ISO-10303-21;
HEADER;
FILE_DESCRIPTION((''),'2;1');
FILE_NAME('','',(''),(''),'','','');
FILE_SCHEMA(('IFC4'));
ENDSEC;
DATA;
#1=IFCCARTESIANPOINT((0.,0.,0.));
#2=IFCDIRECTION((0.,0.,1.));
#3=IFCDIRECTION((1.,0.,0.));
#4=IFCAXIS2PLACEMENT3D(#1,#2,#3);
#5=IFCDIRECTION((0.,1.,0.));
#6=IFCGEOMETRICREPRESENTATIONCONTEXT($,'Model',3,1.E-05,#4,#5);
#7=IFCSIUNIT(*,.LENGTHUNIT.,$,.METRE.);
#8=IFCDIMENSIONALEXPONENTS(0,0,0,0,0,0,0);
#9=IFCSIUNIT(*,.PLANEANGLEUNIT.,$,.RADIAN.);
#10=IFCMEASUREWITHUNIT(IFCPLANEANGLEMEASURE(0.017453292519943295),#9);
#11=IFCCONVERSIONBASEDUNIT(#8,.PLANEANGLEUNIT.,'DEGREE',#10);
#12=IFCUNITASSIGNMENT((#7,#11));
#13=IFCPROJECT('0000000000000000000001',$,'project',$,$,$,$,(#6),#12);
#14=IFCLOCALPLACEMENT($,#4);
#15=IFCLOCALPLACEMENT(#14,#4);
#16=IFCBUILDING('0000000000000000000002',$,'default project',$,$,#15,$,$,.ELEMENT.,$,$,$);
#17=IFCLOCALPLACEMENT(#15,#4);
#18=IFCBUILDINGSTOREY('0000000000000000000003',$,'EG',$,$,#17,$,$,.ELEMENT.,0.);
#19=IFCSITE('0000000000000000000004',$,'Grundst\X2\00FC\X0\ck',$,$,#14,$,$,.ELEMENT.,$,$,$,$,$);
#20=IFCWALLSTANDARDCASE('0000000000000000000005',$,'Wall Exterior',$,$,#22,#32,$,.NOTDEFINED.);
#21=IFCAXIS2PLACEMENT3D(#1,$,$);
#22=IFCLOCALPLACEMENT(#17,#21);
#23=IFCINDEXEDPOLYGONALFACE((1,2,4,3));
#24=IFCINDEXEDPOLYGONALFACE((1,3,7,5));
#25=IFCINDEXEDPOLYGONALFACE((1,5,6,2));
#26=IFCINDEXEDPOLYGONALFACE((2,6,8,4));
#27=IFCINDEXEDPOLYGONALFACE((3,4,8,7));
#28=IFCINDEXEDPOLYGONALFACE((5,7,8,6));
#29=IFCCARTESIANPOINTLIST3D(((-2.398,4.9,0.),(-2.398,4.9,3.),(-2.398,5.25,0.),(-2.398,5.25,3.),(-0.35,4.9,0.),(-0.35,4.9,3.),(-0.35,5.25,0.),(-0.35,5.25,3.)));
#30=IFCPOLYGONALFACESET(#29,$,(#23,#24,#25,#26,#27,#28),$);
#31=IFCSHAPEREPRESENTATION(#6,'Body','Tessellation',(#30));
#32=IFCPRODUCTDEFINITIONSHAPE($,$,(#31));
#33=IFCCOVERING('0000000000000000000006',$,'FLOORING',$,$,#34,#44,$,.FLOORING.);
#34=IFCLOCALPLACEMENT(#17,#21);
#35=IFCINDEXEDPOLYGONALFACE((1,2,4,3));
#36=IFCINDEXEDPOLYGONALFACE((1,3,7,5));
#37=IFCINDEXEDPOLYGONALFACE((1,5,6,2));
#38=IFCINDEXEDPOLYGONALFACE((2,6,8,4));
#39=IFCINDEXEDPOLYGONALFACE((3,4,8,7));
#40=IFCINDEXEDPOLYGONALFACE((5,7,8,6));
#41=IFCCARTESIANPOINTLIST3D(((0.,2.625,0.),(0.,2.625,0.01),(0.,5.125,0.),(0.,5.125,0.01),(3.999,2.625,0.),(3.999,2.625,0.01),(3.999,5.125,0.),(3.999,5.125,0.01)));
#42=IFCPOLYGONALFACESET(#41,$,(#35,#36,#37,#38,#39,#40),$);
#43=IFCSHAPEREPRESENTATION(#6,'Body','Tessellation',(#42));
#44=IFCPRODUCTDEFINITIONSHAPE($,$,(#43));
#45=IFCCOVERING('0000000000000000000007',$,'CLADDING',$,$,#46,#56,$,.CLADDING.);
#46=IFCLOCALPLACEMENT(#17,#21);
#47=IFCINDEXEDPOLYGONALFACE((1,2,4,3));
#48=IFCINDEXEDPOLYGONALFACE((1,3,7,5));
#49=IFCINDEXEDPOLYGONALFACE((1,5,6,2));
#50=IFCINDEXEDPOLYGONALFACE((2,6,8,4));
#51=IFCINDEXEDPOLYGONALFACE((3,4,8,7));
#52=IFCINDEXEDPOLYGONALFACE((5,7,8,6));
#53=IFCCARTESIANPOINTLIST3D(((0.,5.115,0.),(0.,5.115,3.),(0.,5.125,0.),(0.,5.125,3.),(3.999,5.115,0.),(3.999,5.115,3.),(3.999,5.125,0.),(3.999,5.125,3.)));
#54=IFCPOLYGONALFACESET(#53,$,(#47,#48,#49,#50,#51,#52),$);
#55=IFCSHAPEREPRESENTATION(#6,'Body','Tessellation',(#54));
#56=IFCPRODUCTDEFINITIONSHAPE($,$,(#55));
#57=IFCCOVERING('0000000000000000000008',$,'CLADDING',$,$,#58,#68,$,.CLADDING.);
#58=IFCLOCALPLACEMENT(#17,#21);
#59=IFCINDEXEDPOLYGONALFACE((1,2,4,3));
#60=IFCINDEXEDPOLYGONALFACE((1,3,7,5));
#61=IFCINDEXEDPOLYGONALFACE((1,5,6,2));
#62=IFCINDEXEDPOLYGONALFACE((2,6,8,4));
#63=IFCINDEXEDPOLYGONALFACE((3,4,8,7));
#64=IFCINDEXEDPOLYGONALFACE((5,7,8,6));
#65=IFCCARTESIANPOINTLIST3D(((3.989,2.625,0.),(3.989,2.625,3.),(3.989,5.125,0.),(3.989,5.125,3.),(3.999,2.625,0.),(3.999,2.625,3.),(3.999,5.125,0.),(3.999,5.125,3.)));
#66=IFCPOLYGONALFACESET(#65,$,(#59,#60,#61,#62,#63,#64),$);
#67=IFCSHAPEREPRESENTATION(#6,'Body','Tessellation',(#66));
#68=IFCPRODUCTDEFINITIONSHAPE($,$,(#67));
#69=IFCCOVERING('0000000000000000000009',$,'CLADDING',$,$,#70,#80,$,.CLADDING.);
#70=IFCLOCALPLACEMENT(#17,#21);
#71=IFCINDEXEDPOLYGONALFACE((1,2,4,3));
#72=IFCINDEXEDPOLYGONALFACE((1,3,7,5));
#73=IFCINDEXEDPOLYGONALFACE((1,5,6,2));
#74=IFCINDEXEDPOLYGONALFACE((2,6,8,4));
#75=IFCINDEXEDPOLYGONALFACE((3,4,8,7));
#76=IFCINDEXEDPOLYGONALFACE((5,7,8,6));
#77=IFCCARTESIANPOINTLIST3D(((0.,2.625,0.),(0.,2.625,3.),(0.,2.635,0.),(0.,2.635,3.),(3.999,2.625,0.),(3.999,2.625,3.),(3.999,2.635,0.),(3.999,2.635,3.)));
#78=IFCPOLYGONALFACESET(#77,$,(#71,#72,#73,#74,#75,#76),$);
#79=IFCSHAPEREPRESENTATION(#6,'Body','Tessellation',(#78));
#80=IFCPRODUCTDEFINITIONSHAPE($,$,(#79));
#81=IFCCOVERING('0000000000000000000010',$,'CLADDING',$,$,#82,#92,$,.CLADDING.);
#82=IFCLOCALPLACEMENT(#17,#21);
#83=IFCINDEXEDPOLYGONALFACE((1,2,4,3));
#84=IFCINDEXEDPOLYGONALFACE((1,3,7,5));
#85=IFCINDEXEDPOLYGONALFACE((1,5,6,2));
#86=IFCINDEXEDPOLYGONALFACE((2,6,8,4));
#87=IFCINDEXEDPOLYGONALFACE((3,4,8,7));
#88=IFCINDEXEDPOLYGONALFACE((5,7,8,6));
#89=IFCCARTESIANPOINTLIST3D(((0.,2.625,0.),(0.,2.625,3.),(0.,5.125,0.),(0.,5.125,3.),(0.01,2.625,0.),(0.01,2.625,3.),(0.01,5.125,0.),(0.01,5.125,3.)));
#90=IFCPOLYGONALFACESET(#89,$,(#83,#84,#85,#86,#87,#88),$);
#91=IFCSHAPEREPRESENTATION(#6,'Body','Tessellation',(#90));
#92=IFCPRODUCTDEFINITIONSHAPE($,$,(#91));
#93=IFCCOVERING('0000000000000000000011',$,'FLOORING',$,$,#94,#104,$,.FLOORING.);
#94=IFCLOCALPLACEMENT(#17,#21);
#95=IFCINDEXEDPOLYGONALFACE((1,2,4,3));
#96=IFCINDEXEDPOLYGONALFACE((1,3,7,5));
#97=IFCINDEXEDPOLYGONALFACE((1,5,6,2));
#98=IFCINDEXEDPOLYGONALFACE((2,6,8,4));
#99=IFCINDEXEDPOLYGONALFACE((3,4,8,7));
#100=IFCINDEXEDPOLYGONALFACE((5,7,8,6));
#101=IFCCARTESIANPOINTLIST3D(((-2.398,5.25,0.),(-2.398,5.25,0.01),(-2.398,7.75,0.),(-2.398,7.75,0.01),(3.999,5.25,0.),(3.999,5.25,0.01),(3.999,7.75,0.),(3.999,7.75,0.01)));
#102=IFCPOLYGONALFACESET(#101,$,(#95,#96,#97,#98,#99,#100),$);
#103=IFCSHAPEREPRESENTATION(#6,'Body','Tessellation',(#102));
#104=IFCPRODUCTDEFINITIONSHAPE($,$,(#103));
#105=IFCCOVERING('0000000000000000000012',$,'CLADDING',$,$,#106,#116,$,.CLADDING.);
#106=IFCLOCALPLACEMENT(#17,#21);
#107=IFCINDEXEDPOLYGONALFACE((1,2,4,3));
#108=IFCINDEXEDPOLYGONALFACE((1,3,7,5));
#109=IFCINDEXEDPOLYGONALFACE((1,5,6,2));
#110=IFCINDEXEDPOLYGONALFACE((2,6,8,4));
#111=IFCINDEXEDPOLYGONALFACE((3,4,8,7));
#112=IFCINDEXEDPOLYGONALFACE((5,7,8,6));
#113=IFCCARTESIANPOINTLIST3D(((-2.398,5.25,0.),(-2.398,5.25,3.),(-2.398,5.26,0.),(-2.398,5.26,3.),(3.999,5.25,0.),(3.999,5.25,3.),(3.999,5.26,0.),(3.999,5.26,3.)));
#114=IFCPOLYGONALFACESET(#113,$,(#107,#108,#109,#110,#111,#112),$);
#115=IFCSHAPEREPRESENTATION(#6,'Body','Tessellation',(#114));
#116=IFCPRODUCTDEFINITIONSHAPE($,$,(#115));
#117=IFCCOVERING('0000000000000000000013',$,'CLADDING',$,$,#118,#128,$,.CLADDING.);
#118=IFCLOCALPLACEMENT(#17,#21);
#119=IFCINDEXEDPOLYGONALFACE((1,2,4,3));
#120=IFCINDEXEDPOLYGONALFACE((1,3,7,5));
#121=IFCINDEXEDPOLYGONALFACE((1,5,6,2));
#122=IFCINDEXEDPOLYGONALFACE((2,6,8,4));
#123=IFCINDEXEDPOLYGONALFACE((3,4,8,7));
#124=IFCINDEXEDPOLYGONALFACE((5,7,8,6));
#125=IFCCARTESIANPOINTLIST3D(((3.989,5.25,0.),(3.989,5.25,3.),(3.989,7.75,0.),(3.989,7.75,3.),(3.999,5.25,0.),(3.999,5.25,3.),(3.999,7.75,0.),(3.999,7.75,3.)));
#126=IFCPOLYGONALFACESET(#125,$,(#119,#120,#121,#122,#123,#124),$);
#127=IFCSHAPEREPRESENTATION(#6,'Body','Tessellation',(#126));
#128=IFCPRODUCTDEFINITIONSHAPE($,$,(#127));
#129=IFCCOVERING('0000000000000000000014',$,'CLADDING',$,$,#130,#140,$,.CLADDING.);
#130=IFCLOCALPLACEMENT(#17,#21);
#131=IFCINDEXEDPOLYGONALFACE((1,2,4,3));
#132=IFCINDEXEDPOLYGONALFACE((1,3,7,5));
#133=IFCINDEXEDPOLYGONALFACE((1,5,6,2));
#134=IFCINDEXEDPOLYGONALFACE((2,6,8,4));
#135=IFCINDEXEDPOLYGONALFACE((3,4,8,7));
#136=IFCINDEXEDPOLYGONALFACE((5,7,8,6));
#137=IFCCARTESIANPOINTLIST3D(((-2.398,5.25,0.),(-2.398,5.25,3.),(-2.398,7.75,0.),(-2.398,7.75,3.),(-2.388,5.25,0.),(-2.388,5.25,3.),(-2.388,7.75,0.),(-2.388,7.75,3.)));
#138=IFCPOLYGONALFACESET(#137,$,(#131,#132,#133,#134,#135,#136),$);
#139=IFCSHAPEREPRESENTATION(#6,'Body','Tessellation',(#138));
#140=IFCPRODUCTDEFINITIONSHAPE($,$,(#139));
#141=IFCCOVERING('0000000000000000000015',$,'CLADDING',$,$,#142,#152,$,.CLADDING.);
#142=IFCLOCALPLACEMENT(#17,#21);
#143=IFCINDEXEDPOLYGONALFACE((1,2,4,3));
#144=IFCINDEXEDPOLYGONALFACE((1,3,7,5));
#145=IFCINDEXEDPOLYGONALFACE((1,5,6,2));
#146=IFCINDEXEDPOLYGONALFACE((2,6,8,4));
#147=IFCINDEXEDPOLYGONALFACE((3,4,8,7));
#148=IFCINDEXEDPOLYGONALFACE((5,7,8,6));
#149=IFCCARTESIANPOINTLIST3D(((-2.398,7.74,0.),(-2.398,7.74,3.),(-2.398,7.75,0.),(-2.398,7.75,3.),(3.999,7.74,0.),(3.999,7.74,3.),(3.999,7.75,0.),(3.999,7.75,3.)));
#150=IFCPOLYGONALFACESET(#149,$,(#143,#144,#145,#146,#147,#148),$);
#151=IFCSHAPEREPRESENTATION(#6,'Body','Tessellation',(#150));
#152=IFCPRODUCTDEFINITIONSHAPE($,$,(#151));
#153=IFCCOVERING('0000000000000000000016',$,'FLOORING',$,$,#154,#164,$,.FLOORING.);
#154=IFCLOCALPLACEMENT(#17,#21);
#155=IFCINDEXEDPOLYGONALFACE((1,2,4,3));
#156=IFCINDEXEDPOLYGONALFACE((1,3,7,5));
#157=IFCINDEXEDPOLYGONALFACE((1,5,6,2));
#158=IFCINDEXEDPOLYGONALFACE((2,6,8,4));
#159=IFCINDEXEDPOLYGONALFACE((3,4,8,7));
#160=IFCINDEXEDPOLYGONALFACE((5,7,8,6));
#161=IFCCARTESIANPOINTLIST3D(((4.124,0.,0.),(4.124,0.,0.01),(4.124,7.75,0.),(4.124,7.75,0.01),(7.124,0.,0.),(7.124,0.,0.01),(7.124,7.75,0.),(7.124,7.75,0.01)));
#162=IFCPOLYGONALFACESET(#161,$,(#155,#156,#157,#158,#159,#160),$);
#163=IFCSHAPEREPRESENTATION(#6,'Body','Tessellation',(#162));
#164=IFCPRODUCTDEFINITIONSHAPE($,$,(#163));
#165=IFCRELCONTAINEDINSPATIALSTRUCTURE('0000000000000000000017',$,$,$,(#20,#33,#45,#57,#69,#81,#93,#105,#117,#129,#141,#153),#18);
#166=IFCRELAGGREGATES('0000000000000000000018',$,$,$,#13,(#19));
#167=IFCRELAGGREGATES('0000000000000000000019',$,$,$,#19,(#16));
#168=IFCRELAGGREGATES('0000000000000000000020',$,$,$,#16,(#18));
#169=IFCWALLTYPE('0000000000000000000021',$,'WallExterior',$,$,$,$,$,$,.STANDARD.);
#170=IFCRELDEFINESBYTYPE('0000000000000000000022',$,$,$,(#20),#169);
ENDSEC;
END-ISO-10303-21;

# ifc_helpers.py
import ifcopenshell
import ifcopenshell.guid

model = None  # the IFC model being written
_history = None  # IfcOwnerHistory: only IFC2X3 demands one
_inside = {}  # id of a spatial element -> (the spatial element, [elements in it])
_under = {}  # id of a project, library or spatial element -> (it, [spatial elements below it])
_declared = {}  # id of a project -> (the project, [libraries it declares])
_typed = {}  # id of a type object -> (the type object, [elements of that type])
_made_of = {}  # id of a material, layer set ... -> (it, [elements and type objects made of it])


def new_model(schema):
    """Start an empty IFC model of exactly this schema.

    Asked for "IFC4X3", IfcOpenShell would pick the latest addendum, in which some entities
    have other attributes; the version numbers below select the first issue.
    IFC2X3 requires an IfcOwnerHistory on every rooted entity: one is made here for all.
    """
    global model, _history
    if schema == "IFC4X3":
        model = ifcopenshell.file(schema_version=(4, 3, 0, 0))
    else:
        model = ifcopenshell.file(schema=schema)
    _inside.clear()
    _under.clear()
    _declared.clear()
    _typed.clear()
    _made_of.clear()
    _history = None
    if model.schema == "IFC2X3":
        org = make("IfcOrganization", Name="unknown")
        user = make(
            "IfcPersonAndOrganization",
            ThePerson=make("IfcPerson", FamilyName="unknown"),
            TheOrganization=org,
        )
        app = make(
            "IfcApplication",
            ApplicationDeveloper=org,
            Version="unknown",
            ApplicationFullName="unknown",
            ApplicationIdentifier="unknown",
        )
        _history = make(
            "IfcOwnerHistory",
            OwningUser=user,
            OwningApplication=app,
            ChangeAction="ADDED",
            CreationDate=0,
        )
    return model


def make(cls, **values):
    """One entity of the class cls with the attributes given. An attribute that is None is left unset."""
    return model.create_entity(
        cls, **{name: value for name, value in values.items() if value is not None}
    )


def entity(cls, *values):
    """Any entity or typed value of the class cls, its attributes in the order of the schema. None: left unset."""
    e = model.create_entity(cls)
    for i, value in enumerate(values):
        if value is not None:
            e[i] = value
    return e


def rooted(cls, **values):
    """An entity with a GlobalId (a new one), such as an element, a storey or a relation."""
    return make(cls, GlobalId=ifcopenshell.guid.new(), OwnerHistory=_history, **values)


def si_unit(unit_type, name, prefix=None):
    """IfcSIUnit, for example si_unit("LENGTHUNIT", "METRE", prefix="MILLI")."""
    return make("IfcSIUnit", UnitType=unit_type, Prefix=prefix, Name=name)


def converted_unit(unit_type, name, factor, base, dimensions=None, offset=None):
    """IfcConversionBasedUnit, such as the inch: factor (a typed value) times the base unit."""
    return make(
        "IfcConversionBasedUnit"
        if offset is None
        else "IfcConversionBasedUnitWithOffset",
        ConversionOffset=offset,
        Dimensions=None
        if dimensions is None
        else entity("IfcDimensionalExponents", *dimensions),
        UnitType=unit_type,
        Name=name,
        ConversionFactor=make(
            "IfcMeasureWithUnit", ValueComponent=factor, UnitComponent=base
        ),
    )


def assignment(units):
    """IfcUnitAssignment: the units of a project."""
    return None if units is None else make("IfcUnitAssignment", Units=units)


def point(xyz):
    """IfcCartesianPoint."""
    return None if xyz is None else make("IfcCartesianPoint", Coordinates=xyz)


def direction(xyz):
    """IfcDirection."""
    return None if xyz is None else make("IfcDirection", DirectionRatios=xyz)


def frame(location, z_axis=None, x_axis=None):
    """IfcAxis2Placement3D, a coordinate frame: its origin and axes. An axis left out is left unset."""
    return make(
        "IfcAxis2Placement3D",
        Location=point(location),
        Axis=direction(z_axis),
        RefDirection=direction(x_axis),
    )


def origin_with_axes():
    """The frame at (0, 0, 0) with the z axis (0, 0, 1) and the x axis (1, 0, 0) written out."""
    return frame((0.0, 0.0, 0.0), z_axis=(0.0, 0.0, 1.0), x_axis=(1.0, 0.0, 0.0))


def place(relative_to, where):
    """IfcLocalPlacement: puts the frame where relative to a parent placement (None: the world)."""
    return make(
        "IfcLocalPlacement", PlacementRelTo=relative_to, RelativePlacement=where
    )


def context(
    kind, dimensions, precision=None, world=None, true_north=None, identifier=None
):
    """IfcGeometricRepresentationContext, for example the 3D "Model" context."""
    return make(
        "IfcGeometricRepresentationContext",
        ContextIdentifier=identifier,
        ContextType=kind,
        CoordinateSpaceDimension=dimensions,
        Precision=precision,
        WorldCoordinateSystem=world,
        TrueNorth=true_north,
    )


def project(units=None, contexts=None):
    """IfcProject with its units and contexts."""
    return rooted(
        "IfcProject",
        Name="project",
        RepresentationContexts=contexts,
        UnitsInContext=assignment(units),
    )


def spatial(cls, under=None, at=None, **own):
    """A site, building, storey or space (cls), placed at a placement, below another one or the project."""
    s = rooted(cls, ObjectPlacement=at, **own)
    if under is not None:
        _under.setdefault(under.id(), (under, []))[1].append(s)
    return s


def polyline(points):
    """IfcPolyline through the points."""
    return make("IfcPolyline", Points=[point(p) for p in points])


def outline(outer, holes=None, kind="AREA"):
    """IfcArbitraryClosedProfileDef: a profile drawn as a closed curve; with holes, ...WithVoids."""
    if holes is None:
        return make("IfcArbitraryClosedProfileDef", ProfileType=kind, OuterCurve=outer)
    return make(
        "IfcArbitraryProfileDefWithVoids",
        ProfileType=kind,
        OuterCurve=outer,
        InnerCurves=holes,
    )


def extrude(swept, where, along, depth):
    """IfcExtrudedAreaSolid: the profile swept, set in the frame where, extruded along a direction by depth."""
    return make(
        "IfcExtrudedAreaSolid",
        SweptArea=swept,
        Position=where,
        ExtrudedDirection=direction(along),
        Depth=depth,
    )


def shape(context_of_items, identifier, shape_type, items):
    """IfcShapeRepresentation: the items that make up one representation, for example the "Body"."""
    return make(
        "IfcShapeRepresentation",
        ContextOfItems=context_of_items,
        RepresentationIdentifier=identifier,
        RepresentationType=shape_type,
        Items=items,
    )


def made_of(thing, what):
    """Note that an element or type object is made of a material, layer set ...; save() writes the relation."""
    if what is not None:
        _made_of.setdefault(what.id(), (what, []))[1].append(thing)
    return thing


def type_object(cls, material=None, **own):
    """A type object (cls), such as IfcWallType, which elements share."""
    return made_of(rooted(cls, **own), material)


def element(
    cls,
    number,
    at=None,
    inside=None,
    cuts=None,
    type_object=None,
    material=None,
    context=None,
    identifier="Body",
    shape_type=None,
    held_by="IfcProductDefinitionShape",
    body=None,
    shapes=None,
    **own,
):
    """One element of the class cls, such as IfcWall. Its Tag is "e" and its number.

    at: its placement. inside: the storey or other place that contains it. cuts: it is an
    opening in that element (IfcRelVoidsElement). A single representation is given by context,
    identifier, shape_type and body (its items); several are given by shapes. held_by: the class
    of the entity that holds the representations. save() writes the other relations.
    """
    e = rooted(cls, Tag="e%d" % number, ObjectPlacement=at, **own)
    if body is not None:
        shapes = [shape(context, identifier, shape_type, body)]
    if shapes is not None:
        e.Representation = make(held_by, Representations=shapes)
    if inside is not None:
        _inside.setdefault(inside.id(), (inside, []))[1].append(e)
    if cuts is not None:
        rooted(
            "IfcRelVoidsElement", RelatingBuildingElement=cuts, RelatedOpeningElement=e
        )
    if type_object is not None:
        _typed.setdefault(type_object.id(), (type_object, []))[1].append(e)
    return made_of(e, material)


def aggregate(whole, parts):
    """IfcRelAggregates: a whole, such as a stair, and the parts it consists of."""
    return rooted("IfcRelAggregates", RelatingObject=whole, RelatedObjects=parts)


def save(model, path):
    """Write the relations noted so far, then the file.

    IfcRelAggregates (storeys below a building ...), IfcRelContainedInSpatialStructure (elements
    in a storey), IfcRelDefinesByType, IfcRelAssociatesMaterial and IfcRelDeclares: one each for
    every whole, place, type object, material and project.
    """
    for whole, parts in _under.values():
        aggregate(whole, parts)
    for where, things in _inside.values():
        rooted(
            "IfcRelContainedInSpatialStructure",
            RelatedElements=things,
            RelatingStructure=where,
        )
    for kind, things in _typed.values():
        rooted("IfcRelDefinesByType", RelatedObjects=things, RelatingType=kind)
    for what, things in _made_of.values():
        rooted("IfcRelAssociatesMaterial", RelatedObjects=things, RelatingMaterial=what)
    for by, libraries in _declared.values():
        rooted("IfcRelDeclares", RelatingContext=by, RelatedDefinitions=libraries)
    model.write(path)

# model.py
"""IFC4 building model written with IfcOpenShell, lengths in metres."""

from ifc_helpers import new_model, entity, si_unit, converted_unit, direction, frame, origin_with_axes, place, context, project, spatial, polyline, outline, extrude, type_object, element, save


model = new_model("IFC4")

# Units and contexts
model_context = context("Model", 3, precision=1e-05, world=origin_with_axes(), true_north=direction((0.0, 1.0, 0.0)))
ifc_project = project(units=[si_unit("LENGTHUNIT", "METRE"), converted_unit("PLANEANGLEUNIT", "DEGREE", entity("IfcPlaneAngleMeasure", 0.017453292519943295), si_unit("PLANEANGLEUNIT", "RADIAN"), dimensions=[0, 0, 0, 0, 0, 0, 0])], contexts=[model_context])

# Site, building, storey
site_placement = place(None, origin_with_axes())
site = spatial("IfcSite", under=ifc_project, at=site_placement, Name="Grundstück", CompositionType="ELEMENT")
building_placement = place(site_placement, origin_with_axes())
building = spatial("IfcBuilding", under=site, at=building_placement, Name="default project", CompositionType="ELEMENT")
placement_1 = place(building_placement, origin_with_axes())
storey = spatial("IfcBuildingStorey", under=building, at=placement_1, Name="EG", CompositionType="ELEMENT", Elevation=0.0)

# Wall
wall_type_1 = type_object("IfcWallType", Name="WallExterior", PredefinedType="STANDARD")
placement_2 = place(placement_1, frame((-0.175, 5.075, 0.0), z_axis=(0.0, 0.0, 1.0), x_axis=(-1.0, 0.0, 0.0)))
element("IfcWallStandardCase", 1, at=placement_2, inside=storey, type_object=wall_type_1, Name="Wall Exterior", PredefinedType="NOTDEFINED", context=model_context, shape_type="SweptSolid", body=[
    extrude(outline(polyline([(0.175, -0.175), (2.223, -0.175), (2.223, 0.175), (0.175, 0.175), (0.175, -0.175)])), origin_with_axes(), (0.0, 0.0, 1.0), 3.0),
])

# Coverings
element("IfcCovering", 2, at=placement_1, inside=storey, Name="FLOORING", PredefinedType="FLOORING", context=model_context, shape_type="SweptSolid", body=[
    extrude(outline(polyline([(3.999, 5.125), (0.0, 5.125), (0.0, 2.625), (3.999, 2.625), (3.999, 5.125)])), origin_with_axes(), (0.0, 0.0, 1.0), 0.01),
])
element("IfcCovering", 3, at=placement_1, inside=storey, Name="CLADDING", PredefinedType="CLADDING", context=model_context, shape_type="SweptSolid", body=[
    extrude(outline(polyline([(0.0, 5.115), (3.999, 5.115), (3.999, 5.125), (0.0, 5.125), (0.0, 5.115)])), origin_with_axes(), (0.0, 0.0, 1.0), 3.0),
])
element("IfcCovering", 4, at=placement_1, inside=storey, Name="CLADDING", PredefinedType="CLADDING", context=model_context, shape_type="SweptSolid", body=[
    extrude(outline(polyline([(3.989, 5.125), (3.989, 2.625), (3.999, 2.625), (3.999, 5.125), (3.989, 5.125)])), origin_with_axes(), (0.0, 0.0, 1.0), 3.0),
])
element("IfcCovering", 5, at=placement_1, inside=storey, Name="CLADDING", PredefinedType="CLADDING", context=model_context, shape_type="SweptSolid", body=[
    extrude(outline(polyline([(3.999, 2.635), (0.0, 2.635), (0.0, 2.625), (3.999, 2.625), (3.999, 2.635)])), origin_with_axes(), (0.0, 0.0, 1.0), 3.0),
])
element("IfcCovering", 6, at=placement_1, inside=storey, Name="CLADDING", PredefinedType="CLADDING", context=model_context, shape_type="SweptSolid", body=[
    extrude(outline(polyline([(0.01, 2.625), (0.01, 5.125), (0.0, 5.125), (0.0, 2.625), (0.01, 2.625)])), origin_with_axes(), (0.0, 0.0, 1.0), 3.0),
])
element("IfcCovering", 7, at=placement_1, inside=storey, Name="FLOORING", PredefinedType="FLOORING", context=model_context, shape_type="SweptSolid", body=[
    extrude(outline(polyline([(3.999, 7.75), (-2.398, 7.75), (-2.398, 5.25), (3.999, 5.25), (3.999, 7.75)])), origin_with_axes(), (0.0, 0.0, 1.0), 0.01),
])
element("IfcCovering", 8, at=placement_1, inside=storey, Name="CLADDING", PredefinedType="CLADDING", context=model_context, shape_type="SweptSolid", body=[
    extrude(outline(polyline([(3.999, 5.26), (-2.398, 5.26), (-2.398, 5.25), (3.999, 5.25), (3.999, 5.26)])), origin_with_axes(), (0.0, 0.0, 1.0), 3.0),
])
element("IfcCovering", 9, at=placement_1, inside=storey, Name="CLADDING", PredefinedType="CLADDING", context=model_context, shape_type="SweptSolid", body=[
    extrude(outline(polyline([(3.989, 7.75), (3.989, 5.25), (3.999, 5.25), (3.999, 7.75), (3.989, 7.75)])), origin_with_axes(), (0.0, 0.0, 1.0), 3.0),
])
element("IfcCovering", 10, at=placement_1, inside=storey, Name="CLADDING", PredefinedType="CLADDING", context=model_context, shape_type="SweptSolid", body=[
    extrude(outline(polyline([(-2.388, 5.25), (-2.388, 7.75), (-2.398, 7.75), (-2.398, 5.25), (-2.388, 5.25)])), origin_with_axes(), (0.0, 0.0, 1.0), 3.0),
])
element("IfcCovering", 11, at=placement_1, inside=storey, Name="CLADDING", PredefinedType="CLADDING", context=model_context, shape_type="SweptSolid", body=[
    extrude(outline(polyline([(-2.398, 7.74), (3.999, 7.74), (3.999, 7.75), (-2.398, 7.75), (-2.398, 7.74)])), origin_with_axes(), (0.0, 0.0, 1.0), 3.0),
])
element("IfcCovering", 12, at=placement_1, inside=storey, Name="FLOORING", PredefinedType="FLOORING", context=model_context, shape_type="SweptSolid", body=[
    extrude(outline(polyline([(7.124, 7.75), (4.124, 7.75), (4.124, 0.0), (7.124, 0.0), (7.124, 7.75)])), origin_with_axes(), (0.0, 0.0, 1.0), 0.01),
])

save(model, "model.ifc")
